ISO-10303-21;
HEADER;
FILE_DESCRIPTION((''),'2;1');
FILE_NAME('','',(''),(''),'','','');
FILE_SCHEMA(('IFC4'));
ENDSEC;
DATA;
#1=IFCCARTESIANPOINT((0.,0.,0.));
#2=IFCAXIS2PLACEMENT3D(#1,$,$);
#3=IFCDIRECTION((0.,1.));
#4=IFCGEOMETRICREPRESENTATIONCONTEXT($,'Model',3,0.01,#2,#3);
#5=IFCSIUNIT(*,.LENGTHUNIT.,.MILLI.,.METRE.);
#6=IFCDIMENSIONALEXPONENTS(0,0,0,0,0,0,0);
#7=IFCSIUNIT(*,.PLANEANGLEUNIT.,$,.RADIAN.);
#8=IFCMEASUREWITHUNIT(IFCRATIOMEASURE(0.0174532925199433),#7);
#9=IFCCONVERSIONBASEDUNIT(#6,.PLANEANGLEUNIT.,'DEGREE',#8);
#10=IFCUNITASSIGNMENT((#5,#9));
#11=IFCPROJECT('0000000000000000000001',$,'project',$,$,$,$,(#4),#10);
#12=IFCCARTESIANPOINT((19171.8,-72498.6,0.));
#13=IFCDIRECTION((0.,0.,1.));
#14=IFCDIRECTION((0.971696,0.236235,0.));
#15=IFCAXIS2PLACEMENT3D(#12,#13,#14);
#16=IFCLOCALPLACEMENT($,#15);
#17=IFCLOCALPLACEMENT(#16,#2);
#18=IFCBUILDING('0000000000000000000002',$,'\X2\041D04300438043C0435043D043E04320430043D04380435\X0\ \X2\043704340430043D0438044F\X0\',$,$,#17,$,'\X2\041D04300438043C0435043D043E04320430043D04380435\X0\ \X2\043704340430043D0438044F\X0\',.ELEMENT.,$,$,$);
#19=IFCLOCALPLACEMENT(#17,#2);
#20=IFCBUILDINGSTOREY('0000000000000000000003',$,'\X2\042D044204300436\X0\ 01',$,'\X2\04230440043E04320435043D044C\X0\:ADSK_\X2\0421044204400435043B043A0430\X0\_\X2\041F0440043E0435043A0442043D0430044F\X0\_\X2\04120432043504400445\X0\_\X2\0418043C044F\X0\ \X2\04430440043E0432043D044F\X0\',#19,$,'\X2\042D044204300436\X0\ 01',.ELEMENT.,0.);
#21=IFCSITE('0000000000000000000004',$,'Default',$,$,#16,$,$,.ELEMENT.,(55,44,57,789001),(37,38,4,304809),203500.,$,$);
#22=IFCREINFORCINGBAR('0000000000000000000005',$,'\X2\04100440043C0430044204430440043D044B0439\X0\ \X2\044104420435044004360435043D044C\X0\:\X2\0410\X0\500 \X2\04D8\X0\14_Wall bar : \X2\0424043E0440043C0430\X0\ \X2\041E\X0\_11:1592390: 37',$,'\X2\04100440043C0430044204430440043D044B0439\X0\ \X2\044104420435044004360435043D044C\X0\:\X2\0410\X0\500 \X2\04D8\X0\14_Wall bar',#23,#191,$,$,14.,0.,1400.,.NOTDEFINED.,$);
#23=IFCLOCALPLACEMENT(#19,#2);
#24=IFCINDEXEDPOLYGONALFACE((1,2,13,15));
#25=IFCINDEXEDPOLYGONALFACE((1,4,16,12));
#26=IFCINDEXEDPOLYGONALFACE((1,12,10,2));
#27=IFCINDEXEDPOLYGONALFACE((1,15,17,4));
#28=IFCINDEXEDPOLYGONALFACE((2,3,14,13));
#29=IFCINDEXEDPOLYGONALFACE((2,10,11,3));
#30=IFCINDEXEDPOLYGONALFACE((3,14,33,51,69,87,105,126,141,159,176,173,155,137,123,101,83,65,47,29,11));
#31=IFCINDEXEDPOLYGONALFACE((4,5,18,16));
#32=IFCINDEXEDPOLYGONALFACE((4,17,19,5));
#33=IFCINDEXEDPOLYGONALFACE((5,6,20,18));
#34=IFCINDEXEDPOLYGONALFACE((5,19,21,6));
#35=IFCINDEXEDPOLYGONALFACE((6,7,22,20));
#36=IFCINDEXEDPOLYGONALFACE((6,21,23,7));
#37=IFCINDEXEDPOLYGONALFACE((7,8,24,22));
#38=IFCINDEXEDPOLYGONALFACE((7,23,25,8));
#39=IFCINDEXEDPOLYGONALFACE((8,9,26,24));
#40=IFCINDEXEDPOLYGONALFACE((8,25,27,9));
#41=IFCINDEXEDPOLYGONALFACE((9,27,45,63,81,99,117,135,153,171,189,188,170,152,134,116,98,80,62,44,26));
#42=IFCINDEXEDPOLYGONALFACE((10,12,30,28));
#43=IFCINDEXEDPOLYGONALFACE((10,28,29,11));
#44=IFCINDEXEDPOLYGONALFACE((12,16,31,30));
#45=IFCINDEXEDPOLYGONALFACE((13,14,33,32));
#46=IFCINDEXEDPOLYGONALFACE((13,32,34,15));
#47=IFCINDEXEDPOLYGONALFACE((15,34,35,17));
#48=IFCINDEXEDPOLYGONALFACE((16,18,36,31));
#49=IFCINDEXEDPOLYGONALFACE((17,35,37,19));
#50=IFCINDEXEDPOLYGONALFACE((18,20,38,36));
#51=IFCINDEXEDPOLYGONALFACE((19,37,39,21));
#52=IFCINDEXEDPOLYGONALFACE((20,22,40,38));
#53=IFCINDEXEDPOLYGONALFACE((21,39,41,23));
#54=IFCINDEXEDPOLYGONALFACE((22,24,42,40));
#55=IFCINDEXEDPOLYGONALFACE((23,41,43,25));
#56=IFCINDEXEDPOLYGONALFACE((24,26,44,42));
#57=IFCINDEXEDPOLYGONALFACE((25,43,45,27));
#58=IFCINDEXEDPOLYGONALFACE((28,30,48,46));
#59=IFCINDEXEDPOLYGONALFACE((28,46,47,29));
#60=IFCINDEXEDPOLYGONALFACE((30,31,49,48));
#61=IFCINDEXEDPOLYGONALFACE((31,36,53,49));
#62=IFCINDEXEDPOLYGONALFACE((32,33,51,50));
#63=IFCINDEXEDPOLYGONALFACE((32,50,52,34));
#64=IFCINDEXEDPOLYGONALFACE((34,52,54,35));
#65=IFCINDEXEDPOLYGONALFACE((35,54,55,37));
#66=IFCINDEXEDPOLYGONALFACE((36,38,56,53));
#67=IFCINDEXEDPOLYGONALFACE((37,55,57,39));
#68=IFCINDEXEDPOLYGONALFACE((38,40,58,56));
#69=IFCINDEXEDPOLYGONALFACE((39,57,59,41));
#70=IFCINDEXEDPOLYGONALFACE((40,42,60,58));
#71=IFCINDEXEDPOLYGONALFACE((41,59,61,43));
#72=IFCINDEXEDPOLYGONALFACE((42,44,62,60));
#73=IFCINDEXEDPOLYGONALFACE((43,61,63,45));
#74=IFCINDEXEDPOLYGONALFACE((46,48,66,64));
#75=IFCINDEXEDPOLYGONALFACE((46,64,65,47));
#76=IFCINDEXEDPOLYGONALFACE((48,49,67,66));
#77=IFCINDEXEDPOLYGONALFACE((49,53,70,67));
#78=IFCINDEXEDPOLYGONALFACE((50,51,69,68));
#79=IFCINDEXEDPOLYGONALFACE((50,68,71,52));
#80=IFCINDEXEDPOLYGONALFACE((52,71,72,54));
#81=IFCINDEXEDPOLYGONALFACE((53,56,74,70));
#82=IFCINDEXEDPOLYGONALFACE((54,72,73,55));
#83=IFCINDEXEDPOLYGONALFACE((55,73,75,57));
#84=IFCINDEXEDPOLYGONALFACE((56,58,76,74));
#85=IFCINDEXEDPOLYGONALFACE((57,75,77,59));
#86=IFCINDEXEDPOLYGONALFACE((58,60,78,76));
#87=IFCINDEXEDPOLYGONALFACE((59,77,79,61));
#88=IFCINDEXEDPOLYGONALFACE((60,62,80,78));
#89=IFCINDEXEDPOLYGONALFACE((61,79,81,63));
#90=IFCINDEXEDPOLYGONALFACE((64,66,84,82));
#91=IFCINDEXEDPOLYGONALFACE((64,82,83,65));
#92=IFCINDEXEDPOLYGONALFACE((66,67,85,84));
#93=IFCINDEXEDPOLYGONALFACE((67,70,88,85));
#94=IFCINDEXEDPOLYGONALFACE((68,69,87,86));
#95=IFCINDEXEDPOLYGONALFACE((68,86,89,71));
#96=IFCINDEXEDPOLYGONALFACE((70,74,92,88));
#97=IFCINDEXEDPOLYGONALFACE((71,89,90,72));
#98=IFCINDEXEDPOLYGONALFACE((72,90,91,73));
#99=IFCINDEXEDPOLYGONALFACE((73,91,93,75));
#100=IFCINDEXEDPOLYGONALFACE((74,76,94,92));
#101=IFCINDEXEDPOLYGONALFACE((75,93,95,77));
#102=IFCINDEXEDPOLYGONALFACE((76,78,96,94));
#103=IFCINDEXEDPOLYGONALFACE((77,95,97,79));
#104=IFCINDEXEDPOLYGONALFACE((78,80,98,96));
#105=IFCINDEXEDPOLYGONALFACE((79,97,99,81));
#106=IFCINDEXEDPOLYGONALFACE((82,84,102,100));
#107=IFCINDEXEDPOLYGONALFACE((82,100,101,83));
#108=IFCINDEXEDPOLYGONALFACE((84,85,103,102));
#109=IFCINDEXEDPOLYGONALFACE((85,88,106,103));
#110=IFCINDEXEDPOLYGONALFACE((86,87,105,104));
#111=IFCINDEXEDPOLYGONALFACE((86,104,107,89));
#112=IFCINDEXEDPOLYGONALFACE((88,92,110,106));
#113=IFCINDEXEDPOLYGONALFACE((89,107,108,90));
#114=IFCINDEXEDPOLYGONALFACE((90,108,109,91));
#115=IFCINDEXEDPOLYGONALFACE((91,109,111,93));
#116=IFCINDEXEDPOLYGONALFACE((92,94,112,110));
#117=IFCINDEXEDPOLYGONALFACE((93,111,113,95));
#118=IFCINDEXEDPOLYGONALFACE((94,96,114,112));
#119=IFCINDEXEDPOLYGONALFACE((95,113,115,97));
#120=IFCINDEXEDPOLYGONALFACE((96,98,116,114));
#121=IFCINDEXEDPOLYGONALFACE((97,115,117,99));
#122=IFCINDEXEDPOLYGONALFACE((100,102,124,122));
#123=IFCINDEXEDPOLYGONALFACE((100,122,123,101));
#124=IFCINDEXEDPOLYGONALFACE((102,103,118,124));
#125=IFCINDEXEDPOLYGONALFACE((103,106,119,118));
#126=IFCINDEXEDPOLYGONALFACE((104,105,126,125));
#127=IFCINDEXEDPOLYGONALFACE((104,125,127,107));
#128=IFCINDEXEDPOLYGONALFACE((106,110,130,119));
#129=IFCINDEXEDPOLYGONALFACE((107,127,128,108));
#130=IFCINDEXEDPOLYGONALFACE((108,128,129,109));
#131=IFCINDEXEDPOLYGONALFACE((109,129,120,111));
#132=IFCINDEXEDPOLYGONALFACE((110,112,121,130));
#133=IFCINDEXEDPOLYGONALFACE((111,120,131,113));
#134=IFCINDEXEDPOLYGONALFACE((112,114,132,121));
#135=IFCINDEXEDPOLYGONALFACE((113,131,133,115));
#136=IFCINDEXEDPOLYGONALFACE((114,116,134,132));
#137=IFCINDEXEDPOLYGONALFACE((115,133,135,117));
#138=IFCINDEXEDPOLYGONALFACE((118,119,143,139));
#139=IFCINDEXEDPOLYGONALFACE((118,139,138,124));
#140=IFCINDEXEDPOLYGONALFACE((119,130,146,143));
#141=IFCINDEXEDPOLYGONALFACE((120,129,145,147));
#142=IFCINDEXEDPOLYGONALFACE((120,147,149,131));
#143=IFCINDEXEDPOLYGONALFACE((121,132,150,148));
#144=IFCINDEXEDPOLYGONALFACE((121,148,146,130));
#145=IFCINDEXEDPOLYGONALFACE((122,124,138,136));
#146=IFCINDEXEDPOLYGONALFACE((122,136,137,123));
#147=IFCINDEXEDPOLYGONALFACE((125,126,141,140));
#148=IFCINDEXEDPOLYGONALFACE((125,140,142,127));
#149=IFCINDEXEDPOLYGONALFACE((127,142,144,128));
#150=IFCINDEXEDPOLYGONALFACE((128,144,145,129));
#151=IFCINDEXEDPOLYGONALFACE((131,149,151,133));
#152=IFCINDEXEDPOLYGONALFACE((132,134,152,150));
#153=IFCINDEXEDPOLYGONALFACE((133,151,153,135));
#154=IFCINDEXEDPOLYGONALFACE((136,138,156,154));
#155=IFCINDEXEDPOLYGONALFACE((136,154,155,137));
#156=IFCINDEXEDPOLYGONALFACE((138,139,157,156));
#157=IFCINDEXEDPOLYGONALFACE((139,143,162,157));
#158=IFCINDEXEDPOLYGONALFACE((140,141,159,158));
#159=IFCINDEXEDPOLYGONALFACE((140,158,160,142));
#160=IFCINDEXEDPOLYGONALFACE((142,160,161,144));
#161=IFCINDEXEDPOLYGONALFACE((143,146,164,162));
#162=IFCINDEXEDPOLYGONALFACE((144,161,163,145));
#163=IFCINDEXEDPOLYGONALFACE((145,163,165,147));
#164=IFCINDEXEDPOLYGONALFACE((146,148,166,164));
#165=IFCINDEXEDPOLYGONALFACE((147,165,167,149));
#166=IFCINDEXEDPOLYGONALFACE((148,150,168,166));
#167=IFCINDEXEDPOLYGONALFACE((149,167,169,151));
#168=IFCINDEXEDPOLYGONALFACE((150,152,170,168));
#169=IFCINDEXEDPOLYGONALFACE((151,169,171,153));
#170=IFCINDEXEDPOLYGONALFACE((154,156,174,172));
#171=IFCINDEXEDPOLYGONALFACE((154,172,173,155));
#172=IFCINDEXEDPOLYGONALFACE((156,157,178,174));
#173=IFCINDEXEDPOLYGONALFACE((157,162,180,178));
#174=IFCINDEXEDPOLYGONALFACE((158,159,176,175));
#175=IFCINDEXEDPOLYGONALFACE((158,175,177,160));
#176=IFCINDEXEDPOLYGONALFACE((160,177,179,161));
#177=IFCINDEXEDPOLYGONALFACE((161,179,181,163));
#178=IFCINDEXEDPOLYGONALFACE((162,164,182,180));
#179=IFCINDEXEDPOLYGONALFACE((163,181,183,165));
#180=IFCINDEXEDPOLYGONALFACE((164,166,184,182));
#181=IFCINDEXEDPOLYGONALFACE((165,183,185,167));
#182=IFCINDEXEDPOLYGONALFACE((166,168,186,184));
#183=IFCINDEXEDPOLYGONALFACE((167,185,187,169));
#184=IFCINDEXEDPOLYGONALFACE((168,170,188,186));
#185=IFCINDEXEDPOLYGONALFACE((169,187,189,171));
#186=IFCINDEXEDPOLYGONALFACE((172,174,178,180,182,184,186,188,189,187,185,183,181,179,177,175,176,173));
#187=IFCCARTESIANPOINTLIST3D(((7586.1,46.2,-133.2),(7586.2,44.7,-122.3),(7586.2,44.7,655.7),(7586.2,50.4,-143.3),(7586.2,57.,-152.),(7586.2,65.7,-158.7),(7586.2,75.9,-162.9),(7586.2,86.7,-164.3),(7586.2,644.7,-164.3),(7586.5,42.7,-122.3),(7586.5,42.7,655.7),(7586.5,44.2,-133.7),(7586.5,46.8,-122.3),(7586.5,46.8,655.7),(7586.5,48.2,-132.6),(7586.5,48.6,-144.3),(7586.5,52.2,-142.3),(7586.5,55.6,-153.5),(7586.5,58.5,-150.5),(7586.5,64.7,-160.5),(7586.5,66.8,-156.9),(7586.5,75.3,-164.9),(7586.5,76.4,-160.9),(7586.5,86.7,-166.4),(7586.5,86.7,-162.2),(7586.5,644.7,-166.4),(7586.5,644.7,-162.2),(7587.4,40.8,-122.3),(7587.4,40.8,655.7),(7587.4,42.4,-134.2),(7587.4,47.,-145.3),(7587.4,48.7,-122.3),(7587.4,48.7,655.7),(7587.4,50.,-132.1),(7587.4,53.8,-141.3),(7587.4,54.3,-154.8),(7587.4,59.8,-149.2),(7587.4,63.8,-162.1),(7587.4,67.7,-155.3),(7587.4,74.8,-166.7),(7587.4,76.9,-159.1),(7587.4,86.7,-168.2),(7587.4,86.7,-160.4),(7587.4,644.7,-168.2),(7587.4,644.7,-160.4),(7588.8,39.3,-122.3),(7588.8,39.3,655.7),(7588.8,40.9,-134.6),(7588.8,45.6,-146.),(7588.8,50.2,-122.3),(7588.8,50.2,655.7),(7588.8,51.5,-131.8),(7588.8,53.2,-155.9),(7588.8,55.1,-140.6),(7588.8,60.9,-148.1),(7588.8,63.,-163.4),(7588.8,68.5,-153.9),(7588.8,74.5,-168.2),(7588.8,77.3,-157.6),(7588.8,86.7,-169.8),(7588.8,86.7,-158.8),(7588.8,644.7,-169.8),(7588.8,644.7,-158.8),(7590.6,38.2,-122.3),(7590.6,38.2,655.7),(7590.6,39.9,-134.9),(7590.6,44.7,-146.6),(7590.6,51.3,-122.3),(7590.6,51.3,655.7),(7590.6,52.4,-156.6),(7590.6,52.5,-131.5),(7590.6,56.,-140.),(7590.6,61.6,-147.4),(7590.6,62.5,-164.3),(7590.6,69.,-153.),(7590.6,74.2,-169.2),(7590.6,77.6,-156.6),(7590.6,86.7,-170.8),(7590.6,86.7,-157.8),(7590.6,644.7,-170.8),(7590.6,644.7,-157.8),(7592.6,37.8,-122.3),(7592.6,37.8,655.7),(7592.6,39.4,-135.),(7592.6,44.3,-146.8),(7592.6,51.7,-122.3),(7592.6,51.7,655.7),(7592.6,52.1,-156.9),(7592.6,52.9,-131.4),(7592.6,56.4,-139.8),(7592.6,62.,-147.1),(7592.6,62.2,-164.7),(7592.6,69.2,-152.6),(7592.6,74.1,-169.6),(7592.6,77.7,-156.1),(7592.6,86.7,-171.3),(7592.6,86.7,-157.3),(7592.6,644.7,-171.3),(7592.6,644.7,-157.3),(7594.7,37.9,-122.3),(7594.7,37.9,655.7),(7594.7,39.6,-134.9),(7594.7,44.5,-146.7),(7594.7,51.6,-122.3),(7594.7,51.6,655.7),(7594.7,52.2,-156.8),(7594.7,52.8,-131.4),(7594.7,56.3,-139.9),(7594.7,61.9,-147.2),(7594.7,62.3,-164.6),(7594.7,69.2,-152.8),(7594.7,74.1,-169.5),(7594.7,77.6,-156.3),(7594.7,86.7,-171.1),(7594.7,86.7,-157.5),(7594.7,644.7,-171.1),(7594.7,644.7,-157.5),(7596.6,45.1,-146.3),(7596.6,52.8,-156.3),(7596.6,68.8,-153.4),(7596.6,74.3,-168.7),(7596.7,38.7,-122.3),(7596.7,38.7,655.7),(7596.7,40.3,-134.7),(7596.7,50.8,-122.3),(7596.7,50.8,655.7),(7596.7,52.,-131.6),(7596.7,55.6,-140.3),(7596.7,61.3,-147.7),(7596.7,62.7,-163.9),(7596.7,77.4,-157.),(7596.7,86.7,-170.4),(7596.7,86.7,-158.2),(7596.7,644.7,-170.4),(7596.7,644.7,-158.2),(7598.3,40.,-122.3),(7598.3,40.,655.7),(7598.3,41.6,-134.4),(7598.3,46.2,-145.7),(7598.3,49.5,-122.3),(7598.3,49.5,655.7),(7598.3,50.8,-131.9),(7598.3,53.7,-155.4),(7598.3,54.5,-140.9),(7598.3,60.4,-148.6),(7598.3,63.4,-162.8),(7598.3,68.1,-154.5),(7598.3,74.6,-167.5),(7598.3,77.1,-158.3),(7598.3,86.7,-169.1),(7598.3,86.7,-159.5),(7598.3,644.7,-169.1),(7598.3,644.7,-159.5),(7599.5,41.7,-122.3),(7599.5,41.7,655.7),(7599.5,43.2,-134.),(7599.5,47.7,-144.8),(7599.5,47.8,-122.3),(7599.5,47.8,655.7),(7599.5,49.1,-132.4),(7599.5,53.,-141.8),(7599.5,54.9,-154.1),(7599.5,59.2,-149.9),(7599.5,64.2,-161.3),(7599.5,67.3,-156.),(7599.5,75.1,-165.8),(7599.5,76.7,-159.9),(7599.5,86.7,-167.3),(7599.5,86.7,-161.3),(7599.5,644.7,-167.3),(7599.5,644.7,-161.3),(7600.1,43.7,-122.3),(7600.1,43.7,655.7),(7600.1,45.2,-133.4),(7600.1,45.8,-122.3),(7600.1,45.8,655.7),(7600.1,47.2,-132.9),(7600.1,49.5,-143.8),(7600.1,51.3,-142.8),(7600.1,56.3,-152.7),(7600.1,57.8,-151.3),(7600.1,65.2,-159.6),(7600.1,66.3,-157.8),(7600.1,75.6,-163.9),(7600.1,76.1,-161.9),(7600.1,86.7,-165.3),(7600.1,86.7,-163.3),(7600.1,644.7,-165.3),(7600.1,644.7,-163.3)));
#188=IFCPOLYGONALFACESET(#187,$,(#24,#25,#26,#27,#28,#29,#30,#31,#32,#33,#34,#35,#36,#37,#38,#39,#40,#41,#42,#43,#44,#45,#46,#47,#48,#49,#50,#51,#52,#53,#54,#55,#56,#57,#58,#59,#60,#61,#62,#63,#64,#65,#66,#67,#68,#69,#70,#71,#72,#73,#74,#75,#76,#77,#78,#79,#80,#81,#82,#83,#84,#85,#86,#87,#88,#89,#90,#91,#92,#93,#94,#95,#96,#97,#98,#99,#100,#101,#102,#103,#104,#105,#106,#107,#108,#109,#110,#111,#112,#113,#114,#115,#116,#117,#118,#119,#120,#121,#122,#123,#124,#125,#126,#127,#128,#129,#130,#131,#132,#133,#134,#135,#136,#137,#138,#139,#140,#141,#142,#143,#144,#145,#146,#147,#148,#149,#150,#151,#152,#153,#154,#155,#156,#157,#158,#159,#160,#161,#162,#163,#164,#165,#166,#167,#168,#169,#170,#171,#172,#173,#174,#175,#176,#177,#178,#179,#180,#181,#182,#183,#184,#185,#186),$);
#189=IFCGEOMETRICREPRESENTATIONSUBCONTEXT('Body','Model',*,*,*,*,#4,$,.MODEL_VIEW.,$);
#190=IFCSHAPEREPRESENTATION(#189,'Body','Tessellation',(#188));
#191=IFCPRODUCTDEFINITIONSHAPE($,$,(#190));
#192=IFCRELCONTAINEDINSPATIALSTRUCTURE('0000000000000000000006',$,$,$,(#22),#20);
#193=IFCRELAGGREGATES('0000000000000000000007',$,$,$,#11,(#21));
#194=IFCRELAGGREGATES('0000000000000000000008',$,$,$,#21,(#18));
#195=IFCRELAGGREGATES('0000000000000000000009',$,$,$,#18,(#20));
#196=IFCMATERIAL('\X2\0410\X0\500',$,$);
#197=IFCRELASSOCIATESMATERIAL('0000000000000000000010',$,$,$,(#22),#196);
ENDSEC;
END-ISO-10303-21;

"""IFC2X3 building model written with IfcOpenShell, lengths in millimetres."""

from ifc_helpers import new_model, entity, si_unit, converted_unit, direction, frame, origin, place, context, subcontext, project, spatial, material, element, save


model = new_model("IFC2X3")

# Units and contexts
model_context = context("Model", 3, precision=0.01, world=origin(), true_north=direction((0.0, 1.0)))
body_context = subcontext(model_context, "Body", "Model", "MODEL_VIEW")
ifc_project = project(units=[si_unit("LENGTHUNIT", "METRE", prefix="MILLI"), converted_unit("PLANEANGLEUNIT", "DEGREE", entity("IfcRatioMeasure", 0.0174532925199433), si_unit("PLANEANGLEUNIT", "RADIAN"), dimensions=[0, 0, 0, 0, 0, 0, 0])], contexts=[model_context])

# Site, building, storey
site_placement = place(None, frame((19171.8, -72498.6, 0.0), z_axis=(0.0, 0.0, 1.0), x_axis=(0.971696, 0.236235, 0.0)))
site = spatial("IfcSite", under=ifc_project, at=site_placement, Name="Default", CompositionType="ELEMENT", RefLatitude=(55, 44, 57, 789001), RefLongitude=(37, 38, 4, 304809), RefElevation=203500.0)
building_placement = place(site_placement, origin())
building = spatial("IfcBuilding", under=site, at=building_placement, Name="Наименование здания", LongName="Наименование здания", CompositionType="ELEMENT")
storey_placement = place(building_placement, origin())
storey = spatial("IfcBuildingStorey", under=building, at=storey_placement, Name="Этаж 01", ObjectType="Уровень:ADSK_Стрелка_Проектная_Вверх_Имя уровня", LongName="Этаж 01", CompositionType="ELEMENT", Elevation=0.0)

# Reinforcing bar
ifc_material = material(Name="А500")
placement = place(storey_placement, origin())
element("IfcReinforcingBar", 1, at=placement, inside=storey, material=ifc_material, Name="Арматурный стержень:А500 Ә14_Wall bar : Форма О_11:1592390: 37", ObjectType="Арматурный стержень:А500 Ә14_Wall bar", BarLength=1400.0, BarRole="NOTDEFINED", CrossSectionArea=0.0, NominalDiameter=14.0, context=body_context, shape_type="AdvancedSweptSolid", body=[
    entity("IfcSweptDiskSolid", entity("IfcCompositeCurve", [entity("IfcCompositeCurveSegment", "CONTINUOUS", True, entity("IfcPolyline", [entity("IfcCartesianPoint", [7593.1, 44.7, 655.7]), entity("IfcCartesianPoint", [7593.1, 44.7, -122.3])])), entity("IfcCompositeCurveSegment", "CONTINUOUS", True, entity("IfcTrimmedCurve", entity("IfcCircle", entity("IfcAxis2Placement3D", entity("IfcCartesianPoint", [7593.1, 86.7, -122.3]), entity("IfcDirection", [1.0, 0.0, 0.0]), entity("IfcDirection", [0.0, 0.0, -1.0])), 42.0), [entity("IfcParameterValue", 270.0)], [entity("IfcParameterValue", 360.0)], True, "PARAMETER")), entity("IfcCompositeCurveSegment", "CONTINUOUS", True, entity("IfcPolyline", [entity("IfcCartesianPoint", [7593.1, 86.7, -164.3]), entity("IfcCartesianPoint", [7593.1, 644.7, -164.3])]))], False), 7.0, None, 0.0, 92.0),
])

save(model, "model.ifc")
